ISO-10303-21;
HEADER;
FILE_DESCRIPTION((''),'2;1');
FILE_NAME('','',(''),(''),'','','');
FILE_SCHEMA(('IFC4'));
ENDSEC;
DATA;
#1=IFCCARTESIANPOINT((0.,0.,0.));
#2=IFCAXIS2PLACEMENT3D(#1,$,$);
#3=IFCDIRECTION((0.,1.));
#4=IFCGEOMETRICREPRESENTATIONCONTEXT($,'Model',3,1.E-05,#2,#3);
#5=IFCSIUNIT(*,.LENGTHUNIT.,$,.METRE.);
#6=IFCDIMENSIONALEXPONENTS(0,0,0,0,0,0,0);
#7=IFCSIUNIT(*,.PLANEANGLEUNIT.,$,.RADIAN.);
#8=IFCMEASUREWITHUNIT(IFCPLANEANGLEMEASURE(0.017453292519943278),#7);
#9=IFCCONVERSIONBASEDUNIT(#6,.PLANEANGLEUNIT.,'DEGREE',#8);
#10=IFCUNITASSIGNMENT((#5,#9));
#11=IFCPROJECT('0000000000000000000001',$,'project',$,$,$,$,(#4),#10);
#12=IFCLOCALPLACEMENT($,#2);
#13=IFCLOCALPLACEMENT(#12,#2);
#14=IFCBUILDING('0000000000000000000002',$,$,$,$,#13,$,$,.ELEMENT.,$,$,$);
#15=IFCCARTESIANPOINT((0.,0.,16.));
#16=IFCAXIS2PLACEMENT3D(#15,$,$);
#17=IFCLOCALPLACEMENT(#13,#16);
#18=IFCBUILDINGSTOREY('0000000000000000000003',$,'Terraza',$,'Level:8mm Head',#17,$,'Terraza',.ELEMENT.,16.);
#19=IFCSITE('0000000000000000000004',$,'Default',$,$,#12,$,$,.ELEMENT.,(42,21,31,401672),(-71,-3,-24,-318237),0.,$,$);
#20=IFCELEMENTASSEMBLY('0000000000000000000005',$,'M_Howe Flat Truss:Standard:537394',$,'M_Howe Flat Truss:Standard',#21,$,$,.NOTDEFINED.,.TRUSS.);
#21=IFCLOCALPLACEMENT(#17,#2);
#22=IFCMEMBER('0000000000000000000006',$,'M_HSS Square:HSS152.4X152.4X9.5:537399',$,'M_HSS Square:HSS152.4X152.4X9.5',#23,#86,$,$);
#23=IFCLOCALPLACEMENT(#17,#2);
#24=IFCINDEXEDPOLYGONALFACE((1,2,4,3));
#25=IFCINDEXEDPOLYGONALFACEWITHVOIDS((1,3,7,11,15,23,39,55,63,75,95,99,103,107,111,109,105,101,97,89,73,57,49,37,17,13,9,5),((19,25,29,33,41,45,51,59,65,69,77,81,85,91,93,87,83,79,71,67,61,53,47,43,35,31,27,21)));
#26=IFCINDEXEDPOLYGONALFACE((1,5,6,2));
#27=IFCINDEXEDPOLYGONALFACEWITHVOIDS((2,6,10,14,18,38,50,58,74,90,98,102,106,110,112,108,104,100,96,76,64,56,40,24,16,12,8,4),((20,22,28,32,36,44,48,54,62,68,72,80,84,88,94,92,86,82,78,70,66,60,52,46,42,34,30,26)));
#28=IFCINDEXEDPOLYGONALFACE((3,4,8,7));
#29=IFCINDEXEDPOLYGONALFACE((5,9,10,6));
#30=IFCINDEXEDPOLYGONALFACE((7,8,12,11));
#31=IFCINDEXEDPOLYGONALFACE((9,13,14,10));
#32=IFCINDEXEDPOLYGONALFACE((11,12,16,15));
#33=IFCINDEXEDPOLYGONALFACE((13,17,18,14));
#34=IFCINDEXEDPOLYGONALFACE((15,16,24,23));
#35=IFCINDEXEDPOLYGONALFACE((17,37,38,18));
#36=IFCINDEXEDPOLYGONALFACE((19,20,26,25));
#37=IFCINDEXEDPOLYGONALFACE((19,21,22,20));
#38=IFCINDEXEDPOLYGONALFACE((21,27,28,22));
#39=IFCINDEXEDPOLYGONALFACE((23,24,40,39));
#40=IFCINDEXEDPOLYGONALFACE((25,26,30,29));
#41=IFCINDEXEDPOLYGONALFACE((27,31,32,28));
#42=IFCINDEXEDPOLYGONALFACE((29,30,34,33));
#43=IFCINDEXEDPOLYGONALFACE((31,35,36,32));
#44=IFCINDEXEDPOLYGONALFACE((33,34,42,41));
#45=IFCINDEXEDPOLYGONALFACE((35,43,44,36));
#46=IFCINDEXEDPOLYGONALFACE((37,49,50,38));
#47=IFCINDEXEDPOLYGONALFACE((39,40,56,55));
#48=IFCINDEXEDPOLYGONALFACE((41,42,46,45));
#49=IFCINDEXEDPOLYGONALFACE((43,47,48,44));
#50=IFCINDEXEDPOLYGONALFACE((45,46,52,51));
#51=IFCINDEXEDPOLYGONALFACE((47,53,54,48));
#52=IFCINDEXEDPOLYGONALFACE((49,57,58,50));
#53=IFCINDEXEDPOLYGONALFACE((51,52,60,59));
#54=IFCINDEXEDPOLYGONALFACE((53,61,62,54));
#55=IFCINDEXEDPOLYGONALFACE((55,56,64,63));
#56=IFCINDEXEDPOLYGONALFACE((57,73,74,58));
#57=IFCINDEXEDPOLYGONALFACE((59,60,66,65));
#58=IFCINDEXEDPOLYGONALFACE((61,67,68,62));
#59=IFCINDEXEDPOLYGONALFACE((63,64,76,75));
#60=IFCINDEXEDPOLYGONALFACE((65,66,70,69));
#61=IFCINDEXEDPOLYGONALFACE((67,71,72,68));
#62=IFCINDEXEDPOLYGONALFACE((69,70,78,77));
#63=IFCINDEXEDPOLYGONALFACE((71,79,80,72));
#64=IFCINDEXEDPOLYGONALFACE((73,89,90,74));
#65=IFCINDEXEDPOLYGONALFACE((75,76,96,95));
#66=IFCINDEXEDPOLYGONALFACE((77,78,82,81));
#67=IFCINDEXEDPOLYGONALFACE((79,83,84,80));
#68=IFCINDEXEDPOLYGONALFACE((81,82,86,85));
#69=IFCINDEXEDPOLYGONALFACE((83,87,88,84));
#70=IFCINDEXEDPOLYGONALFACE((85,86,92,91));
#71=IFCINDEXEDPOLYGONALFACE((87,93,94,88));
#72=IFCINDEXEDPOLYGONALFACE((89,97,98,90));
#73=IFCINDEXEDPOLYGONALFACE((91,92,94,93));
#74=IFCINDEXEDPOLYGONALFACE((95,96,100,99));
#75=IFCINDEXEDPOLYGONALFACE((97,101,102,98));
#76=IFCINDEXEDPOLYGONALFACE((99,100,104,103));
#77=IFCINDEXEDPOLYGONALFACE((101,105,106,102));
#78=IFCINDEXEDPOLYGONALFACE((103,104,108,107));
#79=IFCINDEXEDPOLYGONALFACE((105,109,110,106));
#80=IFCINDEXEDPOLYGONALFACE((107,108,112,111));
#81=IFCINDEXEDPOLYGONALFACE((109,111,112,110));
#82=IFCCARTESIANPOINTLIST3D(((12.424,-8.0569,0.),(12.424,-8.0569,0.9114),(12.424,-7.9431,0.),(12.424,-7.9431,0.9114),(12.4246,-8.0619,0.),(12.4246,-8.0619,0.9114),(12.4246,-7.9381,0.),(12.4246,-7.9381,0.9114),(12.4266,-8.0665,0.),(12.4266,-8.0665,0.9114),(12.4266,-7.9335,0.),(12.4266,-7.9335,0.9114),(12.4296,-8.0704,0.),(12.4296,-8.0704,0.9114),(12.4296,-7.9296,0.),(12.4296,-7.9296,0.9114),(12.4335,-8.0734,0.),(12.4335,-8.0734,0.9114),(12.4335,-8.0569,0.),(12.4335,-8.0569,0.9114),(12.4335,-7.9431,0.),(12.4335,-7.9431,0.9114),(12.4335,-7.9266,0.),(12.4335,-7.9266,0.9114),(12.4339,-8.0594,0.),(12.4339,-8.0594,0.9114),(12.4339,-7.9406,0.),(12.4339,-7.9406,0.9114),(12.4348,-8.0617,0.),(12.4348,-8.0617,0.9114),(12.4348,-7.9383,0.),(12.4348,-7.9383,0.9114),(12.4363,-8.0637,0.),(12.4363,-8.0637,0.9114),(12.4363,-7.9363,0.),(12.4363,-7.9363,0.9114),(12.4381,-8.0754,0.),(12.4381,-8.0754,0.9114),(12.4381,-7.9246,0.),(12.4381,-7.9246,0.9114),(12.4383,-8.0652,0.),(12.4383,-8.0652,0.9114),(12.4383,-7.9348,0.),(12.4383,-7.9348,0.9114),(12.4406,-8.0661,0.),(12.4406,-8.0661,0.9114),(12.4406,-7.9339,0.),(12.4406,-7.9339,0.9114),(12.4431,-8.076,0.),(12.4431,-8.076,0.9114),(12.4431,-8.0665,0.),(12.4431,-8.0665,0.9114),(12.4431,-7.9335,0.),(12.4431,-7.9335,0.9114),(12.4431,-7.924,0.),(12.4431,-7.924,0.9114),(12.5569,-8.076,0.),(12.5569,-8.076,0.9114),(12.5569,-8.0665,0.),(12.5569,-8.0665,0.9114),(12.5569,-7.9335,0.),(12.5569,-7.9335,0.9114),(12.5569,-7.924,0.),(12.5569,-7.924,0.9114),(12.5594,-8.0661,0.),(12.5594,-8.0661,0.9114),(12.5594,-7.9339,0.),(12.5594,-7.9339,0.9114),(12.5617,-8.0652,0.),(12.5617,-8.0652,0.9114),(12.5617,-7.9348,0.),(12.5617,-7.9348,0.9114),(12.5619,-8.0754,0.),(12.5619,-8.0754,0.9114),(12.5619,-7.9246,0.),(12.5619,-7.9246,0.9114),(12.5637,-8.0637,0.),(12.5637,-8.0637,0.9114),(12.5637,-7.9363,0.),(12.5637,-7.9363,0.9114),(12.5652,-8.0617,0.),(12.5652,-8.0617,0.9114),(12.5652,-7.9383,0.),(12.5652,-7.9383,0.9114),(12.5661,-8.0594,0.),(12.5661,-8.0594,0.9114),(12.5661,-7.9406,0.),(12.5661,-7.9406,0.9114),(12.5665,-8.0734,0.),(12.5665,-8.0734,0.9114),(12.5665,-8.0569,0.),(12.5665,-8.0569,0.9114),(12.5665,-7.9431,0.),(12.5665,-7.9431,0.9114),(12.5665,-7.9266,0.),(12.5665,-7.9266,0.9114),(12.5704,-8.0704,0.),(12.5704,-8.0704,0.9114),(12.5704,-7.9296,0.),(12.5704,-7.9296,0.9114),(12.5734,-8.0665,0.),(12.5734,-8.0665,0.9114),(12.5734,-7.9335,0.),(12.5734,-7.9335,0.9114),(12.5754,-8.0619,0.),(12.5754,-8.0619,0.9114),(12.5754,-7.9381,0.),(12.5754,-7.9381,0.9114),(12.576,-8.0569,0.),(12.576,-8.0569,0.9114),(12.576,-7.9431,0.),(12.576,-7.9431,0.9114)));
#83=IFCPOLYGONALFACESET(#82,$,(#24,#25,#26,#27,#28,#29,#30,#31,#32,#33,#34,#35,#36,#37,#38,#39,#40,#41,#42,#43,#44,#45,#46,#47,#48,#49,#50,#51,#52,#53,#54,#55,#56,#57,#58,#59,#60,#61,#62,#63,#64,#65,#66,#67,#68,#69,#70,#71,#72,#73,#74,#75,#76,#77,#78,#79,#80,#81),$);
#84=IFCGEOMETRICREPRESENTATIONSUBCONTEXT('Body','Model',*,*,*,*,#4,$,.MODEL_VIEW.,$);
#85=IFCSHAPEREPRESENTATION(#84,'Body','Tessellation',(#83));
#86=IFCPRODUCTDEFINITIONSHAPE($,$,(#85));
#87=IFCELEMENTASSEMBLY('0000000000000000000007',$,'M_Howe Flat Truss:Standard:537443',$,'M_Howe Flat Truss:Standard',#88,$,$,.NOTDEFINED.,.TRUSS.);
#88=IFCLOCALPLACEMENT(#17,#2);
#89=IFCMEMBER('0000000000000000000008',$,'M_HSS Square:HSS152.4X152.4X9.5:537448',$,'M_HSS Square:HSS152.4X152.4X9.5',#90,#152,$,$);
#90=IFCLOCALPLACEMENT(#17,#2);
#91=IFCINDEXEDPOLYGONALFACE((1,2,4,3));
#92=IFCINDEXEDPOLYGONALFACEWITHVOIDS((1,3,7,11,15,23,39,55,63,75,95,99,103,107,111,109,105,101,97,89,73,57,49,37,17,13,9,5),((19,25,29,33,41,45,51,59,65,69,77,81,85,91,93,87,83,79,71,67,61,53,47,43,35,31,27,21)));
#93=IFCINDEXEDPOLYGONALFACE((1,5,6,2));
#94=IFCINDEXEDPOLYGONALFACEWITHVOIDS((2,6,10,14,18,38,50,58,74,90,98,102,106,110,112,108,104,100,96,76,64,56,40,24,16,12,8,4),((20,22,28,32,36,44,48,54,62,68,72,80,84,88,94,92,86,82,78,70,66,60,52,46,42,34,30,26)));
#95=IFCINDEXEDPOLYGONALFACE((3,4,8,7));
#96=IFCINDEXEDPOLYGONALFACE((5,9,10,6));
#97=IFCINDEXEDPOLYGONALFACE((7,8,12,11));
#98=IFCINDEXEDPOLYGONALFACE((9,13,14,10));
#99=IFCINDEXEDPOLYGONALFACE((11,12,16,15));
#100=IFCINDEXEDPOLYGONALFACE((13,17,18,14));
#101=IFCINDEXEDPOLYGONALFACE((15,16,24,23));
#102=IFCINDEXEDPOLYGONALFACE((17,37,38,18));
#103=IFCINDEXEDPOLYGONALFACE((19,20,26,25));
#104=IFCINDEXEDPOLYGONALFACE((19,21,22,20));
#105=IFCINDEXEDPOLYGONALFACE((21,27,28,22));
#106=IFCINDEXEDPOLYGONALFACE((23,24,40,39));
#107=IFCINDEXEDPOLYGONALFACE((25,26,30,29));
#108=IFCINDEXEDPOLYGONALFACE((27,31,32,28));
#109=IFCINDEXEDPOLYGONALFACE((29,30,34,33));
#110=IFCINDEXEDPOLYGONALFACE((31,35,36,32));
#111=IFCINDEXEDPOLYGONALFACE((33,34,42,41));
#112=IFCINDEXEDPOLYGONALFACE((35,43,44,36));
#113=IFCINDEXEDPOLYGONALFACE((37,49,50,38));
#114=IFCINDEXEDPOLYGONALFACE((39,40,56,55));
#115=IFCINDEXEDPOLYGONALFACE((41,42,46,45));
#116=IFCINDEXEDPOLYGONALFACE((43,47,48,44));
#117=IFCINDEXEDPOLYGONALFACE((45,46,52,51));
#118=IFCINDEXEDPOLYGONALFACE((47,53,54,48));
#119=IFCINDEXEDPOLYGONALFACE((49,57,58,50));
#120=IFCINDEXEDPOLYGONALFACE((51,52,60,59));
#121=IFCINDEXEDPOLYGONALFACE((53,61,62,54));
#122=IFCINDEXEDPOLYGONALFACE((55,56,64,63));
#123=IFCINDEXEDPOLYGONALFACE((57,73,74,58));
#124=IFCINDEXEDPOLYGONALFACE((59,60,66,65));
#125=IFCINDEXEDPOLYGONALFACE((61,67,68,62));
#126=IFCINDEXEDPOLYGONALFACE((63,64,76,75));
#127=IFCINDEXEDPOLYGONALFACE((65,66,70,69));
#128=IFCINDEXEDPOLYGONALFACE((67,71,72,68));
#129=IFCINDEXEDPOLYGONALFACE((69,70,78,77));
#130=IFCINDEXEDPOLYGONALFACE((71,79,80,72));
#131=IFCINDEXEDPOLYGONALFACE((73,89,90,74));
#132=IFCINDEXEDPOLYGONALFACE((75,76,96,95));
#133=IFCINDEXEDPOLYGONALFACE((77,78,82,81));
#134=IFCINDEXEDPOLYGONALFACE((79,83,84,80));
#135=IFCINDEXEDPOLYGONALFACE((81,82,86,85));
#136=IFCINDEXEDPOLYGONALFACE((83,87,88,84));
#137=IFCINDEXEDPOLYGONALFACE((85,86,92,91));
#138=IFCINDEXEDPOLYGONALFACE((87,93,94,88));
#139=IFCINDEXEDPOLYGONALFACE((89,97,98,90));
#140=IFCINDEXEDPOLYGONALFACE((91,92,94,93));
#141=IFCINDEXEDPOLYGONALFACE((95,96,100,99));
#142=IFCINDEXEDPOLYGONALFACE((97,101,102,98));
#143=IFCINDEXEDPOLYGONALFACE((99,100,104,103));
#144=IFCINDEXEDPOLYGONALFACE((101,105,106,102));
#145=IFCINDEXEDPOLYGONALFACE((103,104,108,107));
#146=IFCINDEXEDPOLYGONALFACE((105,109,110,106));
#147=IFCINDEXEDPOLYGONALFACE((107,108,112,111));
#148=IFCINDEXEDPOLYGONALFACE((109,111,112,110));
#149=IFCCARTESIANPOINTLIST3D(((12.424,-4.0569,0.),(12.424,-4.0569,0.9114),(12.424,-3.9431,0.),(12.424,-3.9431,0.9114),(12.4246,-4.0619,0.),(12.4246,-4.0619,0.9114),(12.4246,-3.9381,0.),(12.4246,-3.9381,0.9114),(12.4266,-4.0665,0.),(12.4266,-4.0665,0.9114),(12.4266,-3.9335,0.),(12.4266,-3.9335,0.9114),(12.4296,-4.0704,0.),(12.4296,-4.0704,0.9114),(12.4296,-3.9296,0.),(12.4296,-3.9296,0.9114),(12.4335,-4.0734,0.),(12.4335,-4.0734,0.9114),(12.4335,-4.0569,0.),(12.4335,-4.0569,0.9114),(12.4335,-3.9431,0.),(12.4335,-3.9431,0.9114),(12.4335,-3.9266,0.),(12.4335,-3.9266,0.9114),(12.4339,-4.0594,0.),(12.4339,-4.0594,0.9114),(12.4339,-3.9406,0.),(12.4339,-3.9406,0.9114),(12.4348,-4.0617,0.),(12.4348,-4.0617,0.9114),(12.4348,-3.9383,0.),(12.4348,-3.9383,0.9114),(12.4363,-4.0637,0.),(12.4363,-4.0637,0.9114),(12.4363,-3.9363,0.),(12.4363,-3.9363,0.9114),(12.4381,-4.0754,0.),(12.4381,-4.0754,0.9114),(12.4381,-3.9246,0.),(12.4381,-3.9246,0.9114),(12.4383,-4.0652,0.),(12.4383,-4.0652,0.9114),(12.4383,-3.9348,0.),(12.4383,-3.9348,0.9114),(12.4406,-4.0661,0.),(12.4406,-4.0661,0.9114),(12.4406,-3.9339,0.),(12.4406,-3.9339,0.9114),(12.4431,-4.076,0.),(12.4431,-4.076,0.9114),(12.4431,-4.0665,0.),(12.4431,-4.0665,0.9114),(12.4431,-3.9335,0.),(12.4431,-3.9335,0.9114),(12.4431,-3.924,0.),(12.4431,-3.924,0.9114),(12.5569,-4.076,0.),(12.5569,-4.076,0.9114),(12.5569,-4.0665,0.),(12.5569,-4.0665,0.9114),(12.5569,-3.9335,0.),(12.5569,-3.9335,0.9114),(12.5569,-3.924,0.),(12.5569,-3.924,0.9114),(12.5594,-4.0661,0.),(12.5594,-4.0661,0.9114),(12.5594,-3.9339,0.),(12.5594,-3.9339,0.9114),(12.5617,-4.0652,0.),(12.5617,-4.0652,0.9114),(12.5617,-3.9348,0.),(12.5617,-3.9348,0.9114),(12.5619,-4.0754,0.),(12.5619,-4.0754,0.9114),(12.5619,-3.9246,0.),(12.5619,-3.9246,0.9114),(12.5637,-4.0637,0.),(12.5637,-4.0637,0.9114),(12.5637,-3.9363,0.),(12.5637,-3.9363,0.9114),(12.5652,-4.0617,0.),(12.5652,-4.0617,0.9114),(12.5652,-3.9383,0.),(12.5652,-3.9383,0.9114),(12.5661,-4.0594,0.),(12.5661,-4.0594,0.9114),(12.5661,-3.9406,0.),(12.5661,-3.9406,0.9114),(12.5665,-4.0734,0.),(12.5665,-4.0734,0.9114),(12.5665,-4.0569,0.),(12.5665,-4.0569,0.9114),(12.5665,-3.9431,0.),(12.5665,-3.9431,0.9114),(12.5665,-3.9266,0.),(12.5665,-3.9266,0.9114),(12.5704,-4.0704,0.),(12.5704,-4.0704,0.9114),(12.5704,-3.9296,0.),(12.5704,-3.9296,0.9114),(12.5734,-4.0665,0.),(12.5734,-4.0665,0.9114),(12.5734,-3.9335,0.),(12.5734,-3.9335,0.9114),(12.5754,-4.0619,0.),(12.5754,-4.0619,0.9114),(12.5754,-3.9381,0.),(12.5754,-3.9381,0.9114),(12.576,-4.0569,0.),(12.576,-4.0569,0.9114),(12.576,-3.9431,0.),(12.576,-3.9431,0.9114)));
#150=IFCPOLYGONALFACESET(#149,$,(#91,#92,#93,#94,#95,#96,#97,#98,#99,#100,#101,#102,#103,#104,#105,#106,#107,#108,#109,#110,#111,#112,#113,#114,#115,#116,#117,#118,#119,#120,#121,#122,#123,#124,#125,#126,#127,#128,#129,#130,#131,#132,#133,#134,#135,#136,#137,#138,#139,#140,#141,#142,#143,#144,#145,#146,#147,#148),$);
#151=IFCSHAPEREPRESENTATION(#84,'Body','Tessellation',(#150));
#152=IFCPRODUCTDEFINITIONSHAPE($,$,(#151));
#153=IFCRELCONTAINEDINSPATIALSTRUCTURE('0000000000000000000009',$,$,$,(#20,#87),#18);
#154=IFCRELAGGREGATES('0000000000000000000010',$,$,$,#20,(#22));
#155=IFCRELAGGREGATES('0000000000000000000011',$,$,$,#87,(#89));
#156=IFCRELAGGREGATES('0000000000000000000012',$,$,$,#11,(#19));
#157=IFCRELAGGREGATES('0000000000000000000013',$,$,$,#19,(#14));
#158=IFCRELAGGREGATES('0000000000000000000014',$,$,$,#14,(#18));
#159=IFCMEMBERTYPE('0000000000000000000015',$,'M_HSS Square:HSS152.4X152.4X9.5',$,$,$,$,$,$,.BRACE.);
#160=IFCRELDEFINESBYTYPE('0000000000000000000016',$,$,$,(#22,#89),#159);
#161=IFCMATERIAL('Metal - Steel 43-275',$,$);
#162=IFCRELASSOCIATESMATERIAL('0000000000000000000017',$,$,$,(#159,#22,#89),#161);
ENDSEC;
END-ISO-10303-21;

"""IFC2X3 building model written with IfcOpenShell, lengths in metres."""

from ifc_helpers import new_model, entity, si_unit, converted_unit, direction, frame, frame_2d, origin, place, context, subcontext, project, spatial, polyline, circle_curve, parameter, trimmed, segment, composite_curve, outline, extrude, source, transform, mapped, material, type_object, type_shapes, element, aggregate, save


model = new_model("IFC2X3")

# Units and contexts
model_context = context("Model", 3, precision=1e-05, world=origin(), true_north=direction((0.0, 1.0)))
body_context = subcontext(model_context, "Body", "Model", "MODEL_VIEW")
ifc_project = project(units=[si_unit("LENGTHUNIT", "METRE"), converted_unit("PLANEANGLEUNIT", "DEGREE", entity("IfcPlaneAngleMeasure", 0.017453292519943278), si_unit("PLANEANGLEUNIT", "RADIAN"), dimensions=[0, 0, 0, 0, 0, 0, 0])], contexts=[model_context])

# Site, building, storey
site_placement = place(None, origin())
site = spatial("IfcSite", under=ifc_project, at=site_placement, Name="Default", CompositionType="ELEMENT", RefLatitude=(42, 21, 31, 401672), RefLongitude=(-71, -3, -24, -318237), RefElevation=0.0)
building_placement = place(site_placement, origin())
building = spatial("IfcBuilding", under=site, at=building_placement, CompositionType="ELEMENT")
storey_placement = place(building_placement, frame((0.0, 0.0, 16.0)))
storey = spatial("IfcBuildingStorey", under=building, at=storey_placement, Name="Terraza", ObjectType="Level:8mm Head", LongName="Terraza", CompositionType="ELEMENT", Elevation=16.0)

# Element assembly
ifc_material = material(Name="Metal - Steel 43-275")
assembly_1_placement = place(storey_placement, origin())
assembly_1 = element("IfcElementAssembly", 1, at=assembly_1_placement, inside=storey, Name="M_Howe Flat Truss:Standard:537394", ObjectType="M_Howe Flat Truss:Standard", AssemblyPlace="NOTDEFINED", PredefinedType="TRUSS")

# Member
member_type_1 = type_object("IfcMemberType", Name="M_HSS Square:HSS152.4X152.4X9.5", PredefinedType="BRACE", material=ifc_material)
shared_shape_1 = source(origin(), body_context, "Body", "SweptSolid", [
    extrude(outline(composite_curve([segment(polyline([(-0.0569, -0.076), (0.0569, -0.076)]), True, "CONTINUOUS"), segment(trimmed(circle_curve(frame_2d((0.0569, -0.0569), x_axis=(0.0, 1.0)), 0.0191), [parameter(180.0)], [parameter(270.0)], True, "PARAMETER"), True, "CONTINUOUS"), segment(polyline([(0.076, -0.0569), (0.076, 0.0569)]), True, "CONTINUOUS"), segment(trimmed(circle_curve(frame_2d((0.0569, 0.0569), x_axis=(0.0, 1.0)), 0.0191), [parameter(270.0)], [parameter(0.0)], True, "PARAMETER"), True, "CONTINUOUS"), segment(polyline([(0.0569, 0.076), (-0.0569, 0.076)]), True, "CONTINUOUS"), segment(trimmed(circle_curve(frame_2d((-0.0569, 0.0569), x_axis=(0.0, 1.0)), 0.0191), [parameter(0.0)], [parameter(90.0)], True, "PARAMETER"), True, "CONTINUOUS"), segment(polyline([(-0.076, 0.0569), (-0.076, -0.0569)]), True, "CONTINUOUS"), segment(trimmed(circle_curve(frame_2d((-0.0569, -0.0569), x_axis=(0.0, 1.0)), 0.0191), [parameter(90.0)], [parameter(180.0)], True, "PARAMETER"), True, "CONTINUOUS")], self_intersect=False), holes=[composite_curve([segment(trimmed(circle_curve(frame_2d((-0.0569, 0.0569), x_axis=(0.0, 1.0)), 0.0095), [parameter(360.0)], [parameter(90.0)], True, "PARAMETER"), False, "CONTINUOUS"), segment(polyline([(-0.0569, 0.0665), (0.0569, 0.0665)]), True, "CONTINUOUS"), segment(trimmed(circle_curve(frame_2d((0.0569, 0.0569), x_axis=(0.0, 1.0)), 0.0095), [parameter(270.0)], [parameter(360.0)], True, "PARAMETER"), False, "CONTINUOUS"), segment(polyline([(0.0665, 0.0569), (0.0665, -0.0569)]), True, "CONTINUOUS"), segment(trimmed(circle_curve(frame_2d((0.0569, -0.0569), x_axis=(0.0, 1.0)), 0.0095), [parameter(180.0)], [parameter(270.0)], True, "PARAMETER"), False, "CONTINUOUS"), segment(polyline([(0.0569, -0.0665), (-0.0569, -0.0665)]), True, "CONTINUOUS"), segment(trimmed(circle_curve(frame_2d((-0.0569, -0.0569), x_axis=(0.0, 1.0)), 0.0095), [parameter(90.0)], [parameter(180.0)], True, "PARAMETER"), False, "CONTINUOUS"), segment(polyline([(-0.0665, -0.0569), (-0.0665, 0.0569)]), True, "CONTINUOUS")], self_intersect=False)]), frame((-0.5, 0.0, 0.0), z_axis=(1.0, 0.0, 0.0), x_axis=(0.0, 0.0, -1.0)), (0.0, 0.0, 1.0), 0.9114),
])
type_shapes(member_type_1, [shared_shape_1])
member_1_placement = place(assembly_1_placement, frame((12.5, -8.0, 0.5), z_axis=(1.0, 0.0, 0.0), x_axis=(0.0, 0.0, 1.0)))
member_1 = element("IfcMember", 2, at=member_1_placement, type_object=member_type_1, material=ifc_material, Name="M_HSS Square:HSS152.4X152.4X9.5:537399", ObjectType="M_HSS Square:HSS152.4X152.4X9.5", context=body_context, shape_type="MappedRepresentation", body=[
    mapped(shared_shape_1, transform((0.0, 0.0, 0.0), scale=1.0)),
])

# Element assembly, member
assembly_2_placement = place(storey_placement, origin())
assembly_2 = element("IfcElementAssembly", 3, at=assembly_2_placement, inside=storey, Name="M_Howe Flat Truss:Standard:537443", ObjectType="M_Howe Flat Truss:Standard", AssemblyPlace="NOTDEFINED", PredefinedType="TRUSS")
member_2_placement = place(assembly_2_placement, frame((12.5, -4.0, 0.5), z_axis=(1.0, 0.0, 0.0), x_axis=(0.0, 0.0, 1.0)))
member_2 = element("IfcMember", 4, at=member_2_placement, type_object=member_type_1, material=ifc_material, Name="M_HSS Square:HSS152.4X152.4X9.5:537448", ObjectType="M_HSS Square:HSS152.4X152.4X9.5", context=body_context, shape_type="MappedRepresentation", body=[
    mapped(shared_shape_1, transform((0.0, 0.0, 0.0), scale=1.0)),
])

aggregate(assembly_1, [member_1])
aggregate(assembly_2, [member_2])

save(model, "model.ifc")
